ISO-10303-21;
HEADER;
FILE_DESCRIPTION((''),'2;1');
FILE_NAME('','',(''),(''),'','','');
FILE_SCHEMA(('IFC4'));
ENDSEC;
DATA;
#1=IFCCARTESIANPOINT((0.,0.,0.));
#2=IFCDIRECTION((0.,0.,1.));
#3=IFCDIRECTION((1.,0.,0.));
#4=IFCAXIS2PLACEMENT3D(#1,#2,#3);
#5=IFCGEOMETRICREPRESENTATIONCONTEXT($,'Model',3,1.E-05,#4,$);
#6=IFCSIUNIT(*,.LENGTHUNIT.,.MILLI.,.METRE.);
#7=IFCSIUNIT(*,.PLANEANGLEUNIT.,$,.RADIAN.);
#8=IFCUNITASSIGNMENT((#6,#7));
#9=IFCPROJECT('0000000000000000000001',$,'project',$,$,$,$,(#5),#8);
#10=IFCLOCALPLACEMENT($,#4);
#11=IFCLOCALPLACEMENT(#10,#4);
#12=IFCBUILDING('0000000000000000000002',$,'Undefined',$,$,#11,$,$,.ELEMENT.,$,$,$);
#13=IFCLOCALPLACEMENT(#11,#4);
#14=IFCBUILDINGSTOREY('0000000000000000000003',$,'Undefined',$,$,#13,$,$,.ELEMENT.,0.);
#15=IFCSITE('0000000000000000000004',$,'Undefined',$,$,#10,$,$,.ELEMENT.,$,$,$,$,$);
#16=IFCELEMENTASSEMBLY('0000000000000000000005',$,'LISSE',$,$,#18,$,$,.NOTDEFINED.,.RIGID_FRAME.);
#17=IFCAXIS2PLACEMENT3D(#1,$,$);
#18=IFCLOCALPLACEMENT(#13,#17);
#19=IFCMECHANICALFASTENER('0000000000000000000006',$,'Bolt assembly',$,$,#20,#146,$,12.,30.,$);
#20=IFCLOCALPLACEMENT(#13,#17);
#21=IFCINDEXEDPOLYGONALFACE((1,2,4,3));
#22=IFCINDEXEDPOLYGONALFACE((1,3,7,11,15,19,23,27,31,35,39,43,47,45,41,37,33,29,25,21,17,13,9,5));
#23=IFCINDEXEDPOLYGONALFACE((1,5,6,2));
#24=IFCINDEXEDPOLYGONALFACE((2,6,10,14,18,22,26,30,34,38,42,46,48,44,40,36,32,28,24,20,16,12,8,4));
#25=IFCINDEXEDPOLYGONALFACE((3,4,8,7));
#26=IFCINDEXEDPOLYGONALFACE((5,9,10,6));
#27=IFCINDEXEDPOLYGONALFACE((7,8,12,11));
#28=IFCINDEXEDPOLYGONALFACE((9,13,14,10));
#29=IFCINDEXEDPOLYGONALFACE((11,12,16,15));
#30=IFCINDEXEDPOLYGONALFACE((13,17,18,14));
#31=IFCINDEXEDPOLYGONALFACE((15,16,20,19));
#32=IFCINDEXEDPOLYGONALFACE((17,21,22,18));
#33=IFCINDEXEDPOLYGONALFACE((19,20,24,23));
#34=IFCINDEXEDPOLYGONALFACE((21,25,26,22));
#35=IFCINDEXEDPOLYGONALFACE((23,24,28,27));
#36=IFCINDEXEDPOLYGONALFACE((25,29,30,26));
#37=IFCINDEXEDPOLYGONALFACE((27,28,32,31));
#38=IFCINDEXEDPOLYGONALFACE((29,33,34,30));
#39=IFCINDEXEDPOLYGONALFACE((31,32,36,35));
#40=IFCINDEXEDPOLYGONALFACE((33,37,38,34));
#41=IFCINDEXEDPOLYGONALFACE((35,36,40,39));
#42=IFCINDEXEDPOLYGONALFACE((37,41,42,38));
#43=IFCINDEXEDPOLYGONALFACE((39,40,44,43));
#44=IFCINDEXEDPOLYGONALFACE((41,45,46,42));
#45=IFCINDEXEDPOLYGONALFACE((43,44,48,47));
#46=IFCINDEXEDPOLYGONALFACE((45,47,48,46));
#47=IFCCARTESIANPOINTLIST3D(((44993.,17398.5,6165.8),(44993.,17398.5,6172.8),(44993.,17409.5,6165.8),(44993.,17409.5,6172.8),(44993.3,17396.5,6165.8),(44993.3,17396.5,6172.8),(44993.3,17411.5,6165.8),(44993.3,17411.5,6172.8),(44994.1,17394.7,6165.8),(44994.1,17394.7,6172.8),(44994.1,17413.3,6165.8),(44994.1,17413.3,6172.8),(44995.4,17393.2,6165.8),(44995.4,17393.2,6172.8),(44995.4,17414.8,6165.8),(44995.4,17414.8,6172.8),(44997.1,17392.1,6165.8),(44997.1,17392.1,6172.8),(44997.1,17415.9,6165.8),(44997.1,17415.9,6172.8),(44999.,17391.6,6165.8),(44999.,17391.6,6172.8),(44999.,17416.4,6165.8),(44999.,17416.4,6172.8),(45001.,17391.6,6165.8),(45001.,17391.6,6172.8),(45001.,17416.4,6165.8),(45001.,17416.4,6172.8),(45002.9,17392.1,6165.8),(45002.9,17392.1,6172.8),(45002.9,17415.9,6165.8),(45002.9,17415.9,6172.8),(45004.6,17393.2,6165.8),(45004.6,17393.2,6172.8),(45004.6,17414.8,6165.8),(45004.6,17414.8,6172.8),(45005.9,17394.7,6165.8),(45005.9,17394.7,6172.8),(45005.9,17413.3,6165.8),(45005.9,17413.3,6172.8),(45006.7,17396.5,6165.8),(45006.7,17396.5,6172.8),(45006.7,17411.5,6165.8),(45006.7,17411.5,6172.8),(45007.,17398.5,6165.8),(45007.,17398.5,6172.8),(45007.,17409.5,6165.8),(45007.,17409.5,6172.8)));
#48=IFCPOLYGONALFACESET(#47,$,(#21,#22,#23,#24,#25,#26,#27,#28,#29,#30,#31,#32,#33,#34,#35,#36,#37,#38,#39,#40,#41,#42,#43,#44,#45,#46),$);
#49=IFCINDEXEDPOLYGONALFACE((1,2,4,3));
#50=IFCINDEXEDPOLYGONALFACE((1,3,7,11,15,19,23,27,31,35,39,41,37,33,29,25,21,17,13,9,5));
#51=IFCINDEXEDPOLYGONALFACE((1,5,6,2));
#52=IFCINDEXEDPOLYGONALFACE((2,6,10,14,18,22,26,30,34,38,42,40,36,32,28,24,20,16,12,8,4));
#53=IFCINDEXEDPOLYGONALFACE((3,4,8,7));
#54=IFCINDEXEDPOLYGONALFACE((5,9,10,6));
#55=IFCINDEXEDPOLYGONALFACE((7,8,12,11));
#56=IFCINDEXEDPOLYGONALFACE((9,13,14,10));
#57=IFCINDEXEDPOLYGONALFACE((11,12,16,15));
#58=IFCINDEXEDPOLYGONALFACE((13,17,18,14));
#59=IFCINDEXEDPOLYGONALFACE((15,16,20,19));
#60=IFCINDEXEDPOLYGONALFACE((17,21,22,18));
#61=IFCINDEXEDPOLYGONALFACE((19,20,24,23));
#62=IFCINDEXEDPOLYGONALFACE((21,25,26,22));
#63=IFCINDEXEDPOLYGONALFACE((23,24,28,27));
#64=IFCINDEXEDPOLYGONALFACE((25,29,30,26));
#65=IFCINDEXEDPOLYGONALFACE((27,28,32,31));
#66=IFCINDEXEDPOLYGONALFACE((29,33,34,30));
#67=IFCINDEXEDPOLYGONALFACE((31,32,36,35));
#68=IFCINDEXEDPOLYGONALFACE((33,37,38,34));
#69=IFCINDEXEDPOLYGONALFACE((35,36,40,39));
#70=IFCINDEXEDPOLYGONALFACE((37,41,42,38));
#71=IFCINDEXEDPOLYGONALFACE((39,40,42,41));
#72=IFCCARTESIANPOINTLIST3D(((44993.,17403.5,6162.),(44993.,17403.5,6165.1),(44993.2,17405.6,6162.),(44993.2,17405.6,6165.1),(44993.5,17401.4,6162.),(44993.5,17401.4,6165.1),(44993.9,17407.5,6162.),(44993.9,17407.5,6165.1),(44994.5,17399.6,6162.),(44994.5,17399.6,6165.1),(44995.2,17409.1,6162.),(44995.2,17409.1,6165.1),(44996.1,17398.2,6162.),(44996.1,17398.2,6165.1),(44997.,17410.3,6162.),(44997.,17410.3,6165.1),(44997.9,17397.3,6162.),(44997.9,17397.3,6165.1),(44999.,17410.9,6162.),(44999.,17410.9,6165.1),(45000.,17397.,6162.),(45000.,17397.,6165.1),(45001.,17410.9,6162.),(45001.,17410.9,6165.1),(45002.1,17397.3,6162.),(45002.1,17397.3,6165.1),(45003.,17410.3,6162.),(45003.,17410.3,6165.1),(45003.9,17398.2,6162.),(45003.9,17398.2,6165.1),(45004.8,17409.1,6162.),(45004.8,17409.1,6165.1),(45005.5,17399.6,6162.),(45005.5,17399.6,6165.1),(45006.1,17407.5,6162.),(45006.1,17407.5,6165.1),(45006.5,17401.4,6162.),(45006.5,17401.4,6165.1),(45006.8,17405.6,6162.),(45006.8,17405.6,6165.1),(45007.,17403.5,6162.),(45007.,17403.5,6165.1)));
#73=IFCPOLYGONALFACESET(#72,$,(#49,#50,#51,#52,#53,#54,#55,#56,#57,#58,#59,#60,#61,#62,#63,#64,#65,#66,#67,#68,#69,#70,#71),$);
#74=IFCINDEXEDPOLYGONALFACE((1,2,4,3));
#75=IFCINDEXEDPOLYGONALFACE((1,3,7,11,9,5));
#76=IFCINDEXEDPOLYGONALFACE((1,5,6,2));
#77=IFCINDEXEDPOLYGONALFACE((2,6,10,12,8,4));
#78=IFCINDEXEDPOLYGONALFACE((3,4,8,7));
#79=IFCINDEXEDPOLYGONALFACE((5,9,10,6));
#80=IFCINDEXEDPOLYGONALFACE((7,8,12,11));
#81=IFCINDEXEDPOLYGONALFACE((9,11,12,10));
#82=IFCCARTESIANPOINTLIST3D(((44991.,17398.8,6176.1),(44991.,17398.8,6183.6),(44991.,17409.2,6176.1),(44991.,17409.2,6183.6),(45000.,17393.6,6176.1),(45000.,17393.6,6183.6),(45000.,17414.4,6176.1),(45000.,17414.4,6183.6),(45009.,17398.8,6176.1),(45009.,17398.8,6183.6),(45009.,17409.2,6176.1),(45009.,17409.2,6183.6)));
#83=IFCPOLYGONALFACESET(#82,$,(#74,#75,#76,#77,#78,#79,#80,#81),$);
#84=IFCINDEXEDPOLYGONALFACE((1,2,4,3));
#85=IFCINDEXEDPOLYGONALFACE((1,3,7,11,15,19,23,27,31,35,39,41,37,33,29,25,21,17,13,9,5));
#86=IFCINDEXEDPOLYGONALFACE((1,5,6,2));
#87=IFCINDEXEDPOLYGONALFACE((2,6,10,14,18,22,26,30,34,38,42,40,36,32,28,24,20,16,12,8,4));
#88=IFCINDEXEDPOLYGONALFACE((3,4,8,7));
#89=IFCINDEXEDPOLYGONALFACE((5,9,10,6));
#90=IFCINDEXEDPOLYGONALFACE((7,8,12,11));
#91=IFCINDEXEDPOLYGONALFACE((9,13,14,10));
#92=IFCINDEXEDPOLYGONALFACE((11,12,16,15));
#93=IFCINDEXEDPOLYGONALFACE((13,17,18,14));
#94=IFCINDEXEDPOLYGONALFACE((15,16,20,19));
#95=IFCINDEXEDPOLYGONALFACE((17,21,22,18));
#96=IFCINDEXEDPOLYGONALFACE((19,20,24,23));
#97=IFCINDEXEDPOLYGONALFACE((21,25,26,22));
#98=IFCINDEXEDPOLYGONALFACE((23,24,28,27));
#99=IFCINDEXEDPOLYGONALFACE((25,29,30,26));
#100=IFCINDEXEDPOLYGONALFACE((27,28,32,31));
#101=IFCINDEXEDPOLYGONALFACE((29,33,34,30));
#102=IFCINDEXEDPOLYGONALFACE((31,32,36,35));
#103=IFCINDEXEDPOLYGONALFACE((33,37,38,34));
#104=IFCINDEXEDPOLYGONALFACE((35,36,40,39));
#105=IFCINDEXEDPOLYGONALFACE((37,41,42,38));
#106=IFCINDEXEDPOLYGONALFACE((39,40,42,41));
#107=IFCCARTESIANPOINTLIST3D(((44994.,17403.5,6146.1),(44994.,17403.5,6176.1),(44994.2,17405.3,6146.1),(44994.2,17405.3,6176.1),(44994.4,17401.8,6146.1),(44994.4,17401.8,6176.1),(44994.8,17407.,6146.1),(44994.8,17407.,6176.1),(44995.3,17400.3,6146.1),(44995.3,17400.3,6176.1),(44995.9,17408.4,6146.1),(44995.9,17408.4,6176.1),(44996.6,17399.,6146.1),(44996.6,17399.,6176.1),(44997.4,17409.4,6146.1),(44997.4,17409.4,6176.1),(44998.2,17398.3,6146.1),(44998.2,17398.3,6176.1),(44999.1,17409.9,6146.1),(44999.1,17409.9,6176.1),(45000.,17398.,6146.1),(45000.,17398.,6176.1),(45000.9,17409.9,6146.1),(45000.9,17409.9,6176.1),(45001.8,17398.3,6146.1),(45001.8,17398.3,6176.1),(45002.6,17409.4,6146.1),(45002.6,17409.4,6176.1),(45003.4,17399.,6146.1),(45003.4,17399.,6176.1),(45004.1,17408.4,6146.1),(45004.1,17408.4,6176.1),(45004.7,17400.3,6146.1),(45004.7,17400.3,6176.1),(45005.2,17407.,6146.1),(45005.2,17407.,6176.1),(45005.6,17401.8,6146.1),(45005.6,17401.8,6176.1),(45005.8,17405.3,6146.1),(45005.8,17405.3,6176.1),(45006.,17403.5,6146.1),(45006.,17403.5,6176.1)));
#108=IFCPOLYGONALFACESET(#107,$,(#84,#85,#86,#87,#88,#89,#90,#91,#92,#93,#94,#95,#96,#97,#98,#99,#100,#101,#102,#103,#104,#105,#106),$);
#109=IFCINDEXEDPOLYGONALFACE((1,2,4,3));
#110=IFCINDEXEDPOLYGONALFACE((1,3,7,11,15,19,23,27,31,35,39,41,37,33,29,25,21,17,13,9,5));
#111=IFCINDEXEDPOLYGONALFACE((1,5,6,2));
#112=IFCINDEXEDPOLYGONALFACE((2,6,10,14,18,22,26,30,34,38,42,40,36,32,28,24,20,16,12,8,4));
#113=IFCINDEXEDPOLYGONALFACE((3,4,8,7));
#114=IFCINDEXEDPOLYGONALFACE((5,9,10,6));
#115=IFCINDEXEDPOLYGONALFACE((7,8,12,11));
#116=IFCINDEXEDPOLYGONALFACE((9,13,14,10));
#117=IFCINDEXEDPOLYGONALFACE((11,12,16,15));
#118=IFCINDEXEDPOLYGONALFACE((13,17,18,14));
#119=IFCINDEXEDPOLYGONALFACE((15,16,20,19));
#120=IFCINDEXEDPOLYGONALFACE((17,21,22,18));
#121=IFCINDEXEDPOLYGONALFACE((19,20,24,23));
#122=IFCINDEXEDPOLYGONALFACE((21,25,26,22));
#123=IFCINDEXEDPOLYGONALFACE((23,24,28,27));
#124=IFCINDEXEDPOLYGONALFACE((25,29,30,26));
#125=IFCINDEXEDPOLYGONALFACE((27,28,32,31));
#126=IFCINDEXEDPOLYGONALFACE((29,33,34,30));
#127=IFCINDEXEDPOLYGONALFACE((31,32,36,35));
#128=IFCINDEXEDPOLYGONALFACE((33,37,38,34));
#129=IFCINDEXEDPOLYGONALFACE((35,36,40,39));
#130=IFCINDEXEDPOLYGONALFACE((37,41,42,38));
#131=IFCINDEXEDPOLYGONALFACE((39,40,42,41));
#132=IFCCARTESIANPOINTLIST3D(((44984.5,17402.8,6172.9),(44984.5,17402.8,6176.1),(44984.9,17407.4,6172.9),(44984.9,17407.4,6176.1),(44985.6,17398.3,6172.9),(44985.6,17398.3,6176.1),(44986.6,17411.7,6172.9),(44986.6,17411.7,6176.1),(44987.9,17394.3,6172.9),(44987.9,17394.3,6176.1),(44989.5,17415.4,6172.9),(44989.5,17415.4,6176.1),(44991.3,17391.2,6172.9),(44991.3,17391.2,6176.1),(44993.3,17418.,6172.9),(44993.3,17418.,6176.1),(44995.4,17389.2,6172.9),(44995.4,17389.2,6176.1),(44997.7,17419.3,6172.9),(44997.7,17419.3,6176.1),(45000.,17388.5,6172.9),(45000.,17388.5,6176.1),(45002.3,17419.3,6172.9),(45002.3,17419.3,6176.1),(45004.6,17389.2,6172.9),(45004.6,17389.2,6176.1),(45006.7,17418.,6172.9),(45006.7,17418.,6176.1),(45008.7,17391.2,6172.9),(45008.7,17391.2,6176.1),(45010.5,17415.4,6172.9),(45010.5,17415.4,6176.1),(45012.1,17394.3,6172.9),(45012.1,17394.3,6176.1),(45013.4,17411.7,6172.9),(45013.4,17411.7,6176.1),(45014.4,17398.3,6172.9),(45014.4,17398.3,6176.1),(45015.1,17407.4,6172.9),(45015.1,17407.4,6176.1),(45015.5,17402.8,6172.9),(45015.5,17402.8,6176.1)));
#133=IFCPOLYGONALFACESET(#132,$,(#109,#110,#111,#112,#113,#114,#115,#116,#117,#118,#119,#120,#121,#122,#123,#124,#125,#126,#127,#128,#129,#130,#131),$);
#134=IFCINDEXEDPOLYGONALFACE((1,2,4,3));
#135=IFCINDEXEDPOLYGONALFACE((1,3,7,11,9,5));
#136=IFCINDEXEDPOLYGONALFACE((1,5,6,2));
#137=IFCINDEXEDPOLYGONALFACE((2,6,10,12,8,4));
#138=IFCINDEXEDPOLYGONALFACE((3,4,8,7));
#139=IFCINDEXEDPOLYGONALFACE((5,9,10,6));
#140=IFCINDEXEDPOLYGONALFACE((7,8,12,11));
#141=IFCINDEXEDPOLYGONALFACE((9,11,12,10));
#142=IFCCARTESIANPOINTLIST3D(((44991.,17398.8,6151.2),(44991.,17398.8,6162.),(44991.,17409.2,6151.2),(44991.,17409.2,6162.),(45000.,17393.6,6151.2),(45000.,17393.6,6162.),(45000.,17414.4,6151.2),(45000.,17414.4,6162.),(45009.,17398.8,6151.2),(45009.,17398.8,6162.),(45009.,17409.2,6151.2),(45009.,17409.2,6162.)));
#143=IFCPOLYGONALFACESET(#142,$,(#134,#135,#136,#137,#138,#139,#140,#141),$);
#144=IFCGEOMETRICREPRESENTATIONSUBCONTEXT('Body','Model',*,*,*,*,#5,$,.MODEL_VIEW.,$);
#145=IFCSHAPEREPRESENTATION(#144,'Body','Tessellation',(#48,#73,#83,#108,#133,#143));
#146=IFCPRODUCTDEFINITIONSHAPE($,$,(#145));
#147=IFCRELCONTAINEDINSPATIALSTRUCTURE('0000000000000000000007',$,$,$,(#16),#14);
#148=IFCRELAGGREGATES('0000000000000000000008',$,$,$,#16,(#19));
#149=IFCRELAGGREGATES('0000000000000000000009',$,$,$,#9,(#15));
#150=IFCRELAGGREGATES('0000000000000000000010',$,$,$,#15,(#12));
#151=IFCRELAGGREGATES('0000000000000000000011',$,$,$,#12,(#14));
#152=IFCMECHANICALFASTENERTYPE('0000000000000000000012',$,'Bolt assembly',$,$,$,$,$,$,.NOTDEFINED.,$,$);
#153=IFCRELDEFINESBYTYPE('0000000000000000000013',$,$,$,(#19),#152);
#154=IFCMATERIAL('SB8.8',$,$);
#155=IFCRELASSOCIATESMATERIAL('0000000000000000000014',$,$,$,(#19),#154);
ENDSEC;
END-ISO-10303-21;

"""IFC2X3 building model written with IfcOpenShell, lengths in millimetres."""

from ifc_helpers import new_model, si_unit, frame, frame_2d, origin_with_axes, origin_2d_with_axis, place, context, subcontext, project, spatial, polyline, circle_curve, parameter, trimmed, segment, composite_curve, circle, outline, extrude, source, transform, mapped, material, type_object, element, aggregate, save


model = new_model("IFC2X3")

# Units and contexts
model_context = context("Model", 3, precision=1e-05, world=origin_with_axes())
body_context = subcontext(model_context, "Body", "Model", "MODEL_VIEW")
ifc_project = project(units=[si_unit("LENGTHUNIT", "METRE", prefix="MILLI"), si_unit("PLANEANGLEUNIT", "RADIAN")], contexts=[model_context])

# Site, building, storey
site_placement = place(None, origin_with_axes())
site = spatial("IfcSite", under=ifc_project, at=site_placement, Name="Undefined", CompositionType="ELEMENT")
building_placement = place(site_placement, origin_with_axes())
building = spatial("IfcBuilding", under=site, at=building_placement, Name="Undefined", CompositionType="ELEMENT")
storey_placement = place(building_placement, origin_with_axes())
storey = spatial("IfcBuildingStorey", under=building, at=storey_placement, Name="Undefined", CompositionType="ELEMENT", Elevation=0.0)

# Element assembly
assembly_1_placement = place(storey_placement, origin_with_axes())
assembly_1 = element("IfcElementAssembly", 1, at=assembly_1_placement, inside=storey, Name="LISSE", AssemblyPlace="NOTDEFINED", PredefinedType="RIGID_FRAME")

# Mechanical fastener
ifc_material_1 = material(Name="SB8.8")
mechanical_fastener_type = type_object("IfcMechanicalFastenerType", Name="Bolt assembly")
shared_shape_1 = source(origin_with_axes(), body_context, "Body", "SweptSolid", [
    extrude(outline(composite_curve([segment(polyline([(-5.5, 7.0), (5.5, 7.0)]), True, "CONTINUOUS"), segment(trimmed(circle_curve(frame_2d((5.5, 0.0), x_axis=(0.0, 1.0)), 7.0), [parameter(0.0)], [parameter(3.141593)], False, "PARAMETER"), True, "CONTINUOUS"), segment(polyline([(5.5, -7.0), (-5.5, -7.0)]), True, "CONTINUOUS"), segment(trimmed(circle_curve(frame_2d((-5.5, 0.0), x_axis=(0.0, -1.0)), 7.0), [parameter(0.0)], [parameter(3.141593)], False, "PARAMETER"), True, "DISCONTINUOUS")], self_intersect=False)), frame((0.0, -6.9, 0.0), z_axis=(0.0, 1.0, 0.0), x_axis=(1.0, 0.0, 0.0)), (0.0, 0.0, 1.0), 7.0),
    extrude(circle(Radius=7.0, at=origin_2d_with_axis()), frame((0.0, 0.8, 0.0), z_axis=(0.0, 1.0, 0.0), x_axis=(1.0, 0.0, 0.0)), (0.0, 0.0, 1.0), 3.1),
    extrude(outline(polyline([(10.4, 0.0), (5.2, 9.0), (-5.2, 9.0), (-10.4, 0.0), (-5.2, -9.0), (5.2, -9.0), (10.4, 0.0)])), frame((0.0, -17.7, 0.0), z_axis=(0.0, 1.0, 0.0), x_axis=(1.0, 0.0, 0.0)), (0.0, 0.0, 1.0), 7.5),
    extrude(circle(Radius=6.0, at=origin_2d_with_axis()), frame((0.0, -10.2, 0.0), z_axis=(0.0, 1.0, 0.0), x_axis=(1.0, 0.0, 0.0)), (0.0, 0.0, 1.0), 30.0),
    extrude(circle(Radius=15.5, at=origin_2d_with_axis()), frame((0.0, -10.2, 0.0), z_axis=(0.0, 1.0, 0.0), x_axis=(1.0, 0.0, 0.0)), (0.0, 0.0, 1.0), 3.2),
    extrude(outline(polyline([(10.4, 0.0), (5.2, 9.0), (-5.2, 9.0), (-10.4, 0.0), (-5.2, -9.0), (5.2, -9.0), (10.4, 0.0)])), frame((0.0, 3.9, 0.0), z_axis=(0.0, 1.0, 0.0), x_axis=(1.0, 0.0, 0.0)), (0.0, 0.0, 1.0), 10.8),
])
mechanical_fastener_1_placement = place(assembly_1_placement, frame((45000.0, 17404.0, 6165.9), z_axis=(1.0, 0.0, 0.0), x_axis=(0.0, -1.0, 0.0)))
mechanical_fastener_1 = element("IfcMechanicalFastener", 2, at=mechanical_fastener_1_placement, type_object=mechanical_fastener_type, material=ifc_material_1, Name="Bolt assembly", NominalDiameter=12.0, NominalLength=30.0, context=body_context, shape_type="MappedRepresentation", body=[
    mapped(shared_shape_1, transform((0.0, 0.0, 0.0))),
])
aggregate(assembly_1, [mechanical_fastener_1])

save(model, "model.ifc")
